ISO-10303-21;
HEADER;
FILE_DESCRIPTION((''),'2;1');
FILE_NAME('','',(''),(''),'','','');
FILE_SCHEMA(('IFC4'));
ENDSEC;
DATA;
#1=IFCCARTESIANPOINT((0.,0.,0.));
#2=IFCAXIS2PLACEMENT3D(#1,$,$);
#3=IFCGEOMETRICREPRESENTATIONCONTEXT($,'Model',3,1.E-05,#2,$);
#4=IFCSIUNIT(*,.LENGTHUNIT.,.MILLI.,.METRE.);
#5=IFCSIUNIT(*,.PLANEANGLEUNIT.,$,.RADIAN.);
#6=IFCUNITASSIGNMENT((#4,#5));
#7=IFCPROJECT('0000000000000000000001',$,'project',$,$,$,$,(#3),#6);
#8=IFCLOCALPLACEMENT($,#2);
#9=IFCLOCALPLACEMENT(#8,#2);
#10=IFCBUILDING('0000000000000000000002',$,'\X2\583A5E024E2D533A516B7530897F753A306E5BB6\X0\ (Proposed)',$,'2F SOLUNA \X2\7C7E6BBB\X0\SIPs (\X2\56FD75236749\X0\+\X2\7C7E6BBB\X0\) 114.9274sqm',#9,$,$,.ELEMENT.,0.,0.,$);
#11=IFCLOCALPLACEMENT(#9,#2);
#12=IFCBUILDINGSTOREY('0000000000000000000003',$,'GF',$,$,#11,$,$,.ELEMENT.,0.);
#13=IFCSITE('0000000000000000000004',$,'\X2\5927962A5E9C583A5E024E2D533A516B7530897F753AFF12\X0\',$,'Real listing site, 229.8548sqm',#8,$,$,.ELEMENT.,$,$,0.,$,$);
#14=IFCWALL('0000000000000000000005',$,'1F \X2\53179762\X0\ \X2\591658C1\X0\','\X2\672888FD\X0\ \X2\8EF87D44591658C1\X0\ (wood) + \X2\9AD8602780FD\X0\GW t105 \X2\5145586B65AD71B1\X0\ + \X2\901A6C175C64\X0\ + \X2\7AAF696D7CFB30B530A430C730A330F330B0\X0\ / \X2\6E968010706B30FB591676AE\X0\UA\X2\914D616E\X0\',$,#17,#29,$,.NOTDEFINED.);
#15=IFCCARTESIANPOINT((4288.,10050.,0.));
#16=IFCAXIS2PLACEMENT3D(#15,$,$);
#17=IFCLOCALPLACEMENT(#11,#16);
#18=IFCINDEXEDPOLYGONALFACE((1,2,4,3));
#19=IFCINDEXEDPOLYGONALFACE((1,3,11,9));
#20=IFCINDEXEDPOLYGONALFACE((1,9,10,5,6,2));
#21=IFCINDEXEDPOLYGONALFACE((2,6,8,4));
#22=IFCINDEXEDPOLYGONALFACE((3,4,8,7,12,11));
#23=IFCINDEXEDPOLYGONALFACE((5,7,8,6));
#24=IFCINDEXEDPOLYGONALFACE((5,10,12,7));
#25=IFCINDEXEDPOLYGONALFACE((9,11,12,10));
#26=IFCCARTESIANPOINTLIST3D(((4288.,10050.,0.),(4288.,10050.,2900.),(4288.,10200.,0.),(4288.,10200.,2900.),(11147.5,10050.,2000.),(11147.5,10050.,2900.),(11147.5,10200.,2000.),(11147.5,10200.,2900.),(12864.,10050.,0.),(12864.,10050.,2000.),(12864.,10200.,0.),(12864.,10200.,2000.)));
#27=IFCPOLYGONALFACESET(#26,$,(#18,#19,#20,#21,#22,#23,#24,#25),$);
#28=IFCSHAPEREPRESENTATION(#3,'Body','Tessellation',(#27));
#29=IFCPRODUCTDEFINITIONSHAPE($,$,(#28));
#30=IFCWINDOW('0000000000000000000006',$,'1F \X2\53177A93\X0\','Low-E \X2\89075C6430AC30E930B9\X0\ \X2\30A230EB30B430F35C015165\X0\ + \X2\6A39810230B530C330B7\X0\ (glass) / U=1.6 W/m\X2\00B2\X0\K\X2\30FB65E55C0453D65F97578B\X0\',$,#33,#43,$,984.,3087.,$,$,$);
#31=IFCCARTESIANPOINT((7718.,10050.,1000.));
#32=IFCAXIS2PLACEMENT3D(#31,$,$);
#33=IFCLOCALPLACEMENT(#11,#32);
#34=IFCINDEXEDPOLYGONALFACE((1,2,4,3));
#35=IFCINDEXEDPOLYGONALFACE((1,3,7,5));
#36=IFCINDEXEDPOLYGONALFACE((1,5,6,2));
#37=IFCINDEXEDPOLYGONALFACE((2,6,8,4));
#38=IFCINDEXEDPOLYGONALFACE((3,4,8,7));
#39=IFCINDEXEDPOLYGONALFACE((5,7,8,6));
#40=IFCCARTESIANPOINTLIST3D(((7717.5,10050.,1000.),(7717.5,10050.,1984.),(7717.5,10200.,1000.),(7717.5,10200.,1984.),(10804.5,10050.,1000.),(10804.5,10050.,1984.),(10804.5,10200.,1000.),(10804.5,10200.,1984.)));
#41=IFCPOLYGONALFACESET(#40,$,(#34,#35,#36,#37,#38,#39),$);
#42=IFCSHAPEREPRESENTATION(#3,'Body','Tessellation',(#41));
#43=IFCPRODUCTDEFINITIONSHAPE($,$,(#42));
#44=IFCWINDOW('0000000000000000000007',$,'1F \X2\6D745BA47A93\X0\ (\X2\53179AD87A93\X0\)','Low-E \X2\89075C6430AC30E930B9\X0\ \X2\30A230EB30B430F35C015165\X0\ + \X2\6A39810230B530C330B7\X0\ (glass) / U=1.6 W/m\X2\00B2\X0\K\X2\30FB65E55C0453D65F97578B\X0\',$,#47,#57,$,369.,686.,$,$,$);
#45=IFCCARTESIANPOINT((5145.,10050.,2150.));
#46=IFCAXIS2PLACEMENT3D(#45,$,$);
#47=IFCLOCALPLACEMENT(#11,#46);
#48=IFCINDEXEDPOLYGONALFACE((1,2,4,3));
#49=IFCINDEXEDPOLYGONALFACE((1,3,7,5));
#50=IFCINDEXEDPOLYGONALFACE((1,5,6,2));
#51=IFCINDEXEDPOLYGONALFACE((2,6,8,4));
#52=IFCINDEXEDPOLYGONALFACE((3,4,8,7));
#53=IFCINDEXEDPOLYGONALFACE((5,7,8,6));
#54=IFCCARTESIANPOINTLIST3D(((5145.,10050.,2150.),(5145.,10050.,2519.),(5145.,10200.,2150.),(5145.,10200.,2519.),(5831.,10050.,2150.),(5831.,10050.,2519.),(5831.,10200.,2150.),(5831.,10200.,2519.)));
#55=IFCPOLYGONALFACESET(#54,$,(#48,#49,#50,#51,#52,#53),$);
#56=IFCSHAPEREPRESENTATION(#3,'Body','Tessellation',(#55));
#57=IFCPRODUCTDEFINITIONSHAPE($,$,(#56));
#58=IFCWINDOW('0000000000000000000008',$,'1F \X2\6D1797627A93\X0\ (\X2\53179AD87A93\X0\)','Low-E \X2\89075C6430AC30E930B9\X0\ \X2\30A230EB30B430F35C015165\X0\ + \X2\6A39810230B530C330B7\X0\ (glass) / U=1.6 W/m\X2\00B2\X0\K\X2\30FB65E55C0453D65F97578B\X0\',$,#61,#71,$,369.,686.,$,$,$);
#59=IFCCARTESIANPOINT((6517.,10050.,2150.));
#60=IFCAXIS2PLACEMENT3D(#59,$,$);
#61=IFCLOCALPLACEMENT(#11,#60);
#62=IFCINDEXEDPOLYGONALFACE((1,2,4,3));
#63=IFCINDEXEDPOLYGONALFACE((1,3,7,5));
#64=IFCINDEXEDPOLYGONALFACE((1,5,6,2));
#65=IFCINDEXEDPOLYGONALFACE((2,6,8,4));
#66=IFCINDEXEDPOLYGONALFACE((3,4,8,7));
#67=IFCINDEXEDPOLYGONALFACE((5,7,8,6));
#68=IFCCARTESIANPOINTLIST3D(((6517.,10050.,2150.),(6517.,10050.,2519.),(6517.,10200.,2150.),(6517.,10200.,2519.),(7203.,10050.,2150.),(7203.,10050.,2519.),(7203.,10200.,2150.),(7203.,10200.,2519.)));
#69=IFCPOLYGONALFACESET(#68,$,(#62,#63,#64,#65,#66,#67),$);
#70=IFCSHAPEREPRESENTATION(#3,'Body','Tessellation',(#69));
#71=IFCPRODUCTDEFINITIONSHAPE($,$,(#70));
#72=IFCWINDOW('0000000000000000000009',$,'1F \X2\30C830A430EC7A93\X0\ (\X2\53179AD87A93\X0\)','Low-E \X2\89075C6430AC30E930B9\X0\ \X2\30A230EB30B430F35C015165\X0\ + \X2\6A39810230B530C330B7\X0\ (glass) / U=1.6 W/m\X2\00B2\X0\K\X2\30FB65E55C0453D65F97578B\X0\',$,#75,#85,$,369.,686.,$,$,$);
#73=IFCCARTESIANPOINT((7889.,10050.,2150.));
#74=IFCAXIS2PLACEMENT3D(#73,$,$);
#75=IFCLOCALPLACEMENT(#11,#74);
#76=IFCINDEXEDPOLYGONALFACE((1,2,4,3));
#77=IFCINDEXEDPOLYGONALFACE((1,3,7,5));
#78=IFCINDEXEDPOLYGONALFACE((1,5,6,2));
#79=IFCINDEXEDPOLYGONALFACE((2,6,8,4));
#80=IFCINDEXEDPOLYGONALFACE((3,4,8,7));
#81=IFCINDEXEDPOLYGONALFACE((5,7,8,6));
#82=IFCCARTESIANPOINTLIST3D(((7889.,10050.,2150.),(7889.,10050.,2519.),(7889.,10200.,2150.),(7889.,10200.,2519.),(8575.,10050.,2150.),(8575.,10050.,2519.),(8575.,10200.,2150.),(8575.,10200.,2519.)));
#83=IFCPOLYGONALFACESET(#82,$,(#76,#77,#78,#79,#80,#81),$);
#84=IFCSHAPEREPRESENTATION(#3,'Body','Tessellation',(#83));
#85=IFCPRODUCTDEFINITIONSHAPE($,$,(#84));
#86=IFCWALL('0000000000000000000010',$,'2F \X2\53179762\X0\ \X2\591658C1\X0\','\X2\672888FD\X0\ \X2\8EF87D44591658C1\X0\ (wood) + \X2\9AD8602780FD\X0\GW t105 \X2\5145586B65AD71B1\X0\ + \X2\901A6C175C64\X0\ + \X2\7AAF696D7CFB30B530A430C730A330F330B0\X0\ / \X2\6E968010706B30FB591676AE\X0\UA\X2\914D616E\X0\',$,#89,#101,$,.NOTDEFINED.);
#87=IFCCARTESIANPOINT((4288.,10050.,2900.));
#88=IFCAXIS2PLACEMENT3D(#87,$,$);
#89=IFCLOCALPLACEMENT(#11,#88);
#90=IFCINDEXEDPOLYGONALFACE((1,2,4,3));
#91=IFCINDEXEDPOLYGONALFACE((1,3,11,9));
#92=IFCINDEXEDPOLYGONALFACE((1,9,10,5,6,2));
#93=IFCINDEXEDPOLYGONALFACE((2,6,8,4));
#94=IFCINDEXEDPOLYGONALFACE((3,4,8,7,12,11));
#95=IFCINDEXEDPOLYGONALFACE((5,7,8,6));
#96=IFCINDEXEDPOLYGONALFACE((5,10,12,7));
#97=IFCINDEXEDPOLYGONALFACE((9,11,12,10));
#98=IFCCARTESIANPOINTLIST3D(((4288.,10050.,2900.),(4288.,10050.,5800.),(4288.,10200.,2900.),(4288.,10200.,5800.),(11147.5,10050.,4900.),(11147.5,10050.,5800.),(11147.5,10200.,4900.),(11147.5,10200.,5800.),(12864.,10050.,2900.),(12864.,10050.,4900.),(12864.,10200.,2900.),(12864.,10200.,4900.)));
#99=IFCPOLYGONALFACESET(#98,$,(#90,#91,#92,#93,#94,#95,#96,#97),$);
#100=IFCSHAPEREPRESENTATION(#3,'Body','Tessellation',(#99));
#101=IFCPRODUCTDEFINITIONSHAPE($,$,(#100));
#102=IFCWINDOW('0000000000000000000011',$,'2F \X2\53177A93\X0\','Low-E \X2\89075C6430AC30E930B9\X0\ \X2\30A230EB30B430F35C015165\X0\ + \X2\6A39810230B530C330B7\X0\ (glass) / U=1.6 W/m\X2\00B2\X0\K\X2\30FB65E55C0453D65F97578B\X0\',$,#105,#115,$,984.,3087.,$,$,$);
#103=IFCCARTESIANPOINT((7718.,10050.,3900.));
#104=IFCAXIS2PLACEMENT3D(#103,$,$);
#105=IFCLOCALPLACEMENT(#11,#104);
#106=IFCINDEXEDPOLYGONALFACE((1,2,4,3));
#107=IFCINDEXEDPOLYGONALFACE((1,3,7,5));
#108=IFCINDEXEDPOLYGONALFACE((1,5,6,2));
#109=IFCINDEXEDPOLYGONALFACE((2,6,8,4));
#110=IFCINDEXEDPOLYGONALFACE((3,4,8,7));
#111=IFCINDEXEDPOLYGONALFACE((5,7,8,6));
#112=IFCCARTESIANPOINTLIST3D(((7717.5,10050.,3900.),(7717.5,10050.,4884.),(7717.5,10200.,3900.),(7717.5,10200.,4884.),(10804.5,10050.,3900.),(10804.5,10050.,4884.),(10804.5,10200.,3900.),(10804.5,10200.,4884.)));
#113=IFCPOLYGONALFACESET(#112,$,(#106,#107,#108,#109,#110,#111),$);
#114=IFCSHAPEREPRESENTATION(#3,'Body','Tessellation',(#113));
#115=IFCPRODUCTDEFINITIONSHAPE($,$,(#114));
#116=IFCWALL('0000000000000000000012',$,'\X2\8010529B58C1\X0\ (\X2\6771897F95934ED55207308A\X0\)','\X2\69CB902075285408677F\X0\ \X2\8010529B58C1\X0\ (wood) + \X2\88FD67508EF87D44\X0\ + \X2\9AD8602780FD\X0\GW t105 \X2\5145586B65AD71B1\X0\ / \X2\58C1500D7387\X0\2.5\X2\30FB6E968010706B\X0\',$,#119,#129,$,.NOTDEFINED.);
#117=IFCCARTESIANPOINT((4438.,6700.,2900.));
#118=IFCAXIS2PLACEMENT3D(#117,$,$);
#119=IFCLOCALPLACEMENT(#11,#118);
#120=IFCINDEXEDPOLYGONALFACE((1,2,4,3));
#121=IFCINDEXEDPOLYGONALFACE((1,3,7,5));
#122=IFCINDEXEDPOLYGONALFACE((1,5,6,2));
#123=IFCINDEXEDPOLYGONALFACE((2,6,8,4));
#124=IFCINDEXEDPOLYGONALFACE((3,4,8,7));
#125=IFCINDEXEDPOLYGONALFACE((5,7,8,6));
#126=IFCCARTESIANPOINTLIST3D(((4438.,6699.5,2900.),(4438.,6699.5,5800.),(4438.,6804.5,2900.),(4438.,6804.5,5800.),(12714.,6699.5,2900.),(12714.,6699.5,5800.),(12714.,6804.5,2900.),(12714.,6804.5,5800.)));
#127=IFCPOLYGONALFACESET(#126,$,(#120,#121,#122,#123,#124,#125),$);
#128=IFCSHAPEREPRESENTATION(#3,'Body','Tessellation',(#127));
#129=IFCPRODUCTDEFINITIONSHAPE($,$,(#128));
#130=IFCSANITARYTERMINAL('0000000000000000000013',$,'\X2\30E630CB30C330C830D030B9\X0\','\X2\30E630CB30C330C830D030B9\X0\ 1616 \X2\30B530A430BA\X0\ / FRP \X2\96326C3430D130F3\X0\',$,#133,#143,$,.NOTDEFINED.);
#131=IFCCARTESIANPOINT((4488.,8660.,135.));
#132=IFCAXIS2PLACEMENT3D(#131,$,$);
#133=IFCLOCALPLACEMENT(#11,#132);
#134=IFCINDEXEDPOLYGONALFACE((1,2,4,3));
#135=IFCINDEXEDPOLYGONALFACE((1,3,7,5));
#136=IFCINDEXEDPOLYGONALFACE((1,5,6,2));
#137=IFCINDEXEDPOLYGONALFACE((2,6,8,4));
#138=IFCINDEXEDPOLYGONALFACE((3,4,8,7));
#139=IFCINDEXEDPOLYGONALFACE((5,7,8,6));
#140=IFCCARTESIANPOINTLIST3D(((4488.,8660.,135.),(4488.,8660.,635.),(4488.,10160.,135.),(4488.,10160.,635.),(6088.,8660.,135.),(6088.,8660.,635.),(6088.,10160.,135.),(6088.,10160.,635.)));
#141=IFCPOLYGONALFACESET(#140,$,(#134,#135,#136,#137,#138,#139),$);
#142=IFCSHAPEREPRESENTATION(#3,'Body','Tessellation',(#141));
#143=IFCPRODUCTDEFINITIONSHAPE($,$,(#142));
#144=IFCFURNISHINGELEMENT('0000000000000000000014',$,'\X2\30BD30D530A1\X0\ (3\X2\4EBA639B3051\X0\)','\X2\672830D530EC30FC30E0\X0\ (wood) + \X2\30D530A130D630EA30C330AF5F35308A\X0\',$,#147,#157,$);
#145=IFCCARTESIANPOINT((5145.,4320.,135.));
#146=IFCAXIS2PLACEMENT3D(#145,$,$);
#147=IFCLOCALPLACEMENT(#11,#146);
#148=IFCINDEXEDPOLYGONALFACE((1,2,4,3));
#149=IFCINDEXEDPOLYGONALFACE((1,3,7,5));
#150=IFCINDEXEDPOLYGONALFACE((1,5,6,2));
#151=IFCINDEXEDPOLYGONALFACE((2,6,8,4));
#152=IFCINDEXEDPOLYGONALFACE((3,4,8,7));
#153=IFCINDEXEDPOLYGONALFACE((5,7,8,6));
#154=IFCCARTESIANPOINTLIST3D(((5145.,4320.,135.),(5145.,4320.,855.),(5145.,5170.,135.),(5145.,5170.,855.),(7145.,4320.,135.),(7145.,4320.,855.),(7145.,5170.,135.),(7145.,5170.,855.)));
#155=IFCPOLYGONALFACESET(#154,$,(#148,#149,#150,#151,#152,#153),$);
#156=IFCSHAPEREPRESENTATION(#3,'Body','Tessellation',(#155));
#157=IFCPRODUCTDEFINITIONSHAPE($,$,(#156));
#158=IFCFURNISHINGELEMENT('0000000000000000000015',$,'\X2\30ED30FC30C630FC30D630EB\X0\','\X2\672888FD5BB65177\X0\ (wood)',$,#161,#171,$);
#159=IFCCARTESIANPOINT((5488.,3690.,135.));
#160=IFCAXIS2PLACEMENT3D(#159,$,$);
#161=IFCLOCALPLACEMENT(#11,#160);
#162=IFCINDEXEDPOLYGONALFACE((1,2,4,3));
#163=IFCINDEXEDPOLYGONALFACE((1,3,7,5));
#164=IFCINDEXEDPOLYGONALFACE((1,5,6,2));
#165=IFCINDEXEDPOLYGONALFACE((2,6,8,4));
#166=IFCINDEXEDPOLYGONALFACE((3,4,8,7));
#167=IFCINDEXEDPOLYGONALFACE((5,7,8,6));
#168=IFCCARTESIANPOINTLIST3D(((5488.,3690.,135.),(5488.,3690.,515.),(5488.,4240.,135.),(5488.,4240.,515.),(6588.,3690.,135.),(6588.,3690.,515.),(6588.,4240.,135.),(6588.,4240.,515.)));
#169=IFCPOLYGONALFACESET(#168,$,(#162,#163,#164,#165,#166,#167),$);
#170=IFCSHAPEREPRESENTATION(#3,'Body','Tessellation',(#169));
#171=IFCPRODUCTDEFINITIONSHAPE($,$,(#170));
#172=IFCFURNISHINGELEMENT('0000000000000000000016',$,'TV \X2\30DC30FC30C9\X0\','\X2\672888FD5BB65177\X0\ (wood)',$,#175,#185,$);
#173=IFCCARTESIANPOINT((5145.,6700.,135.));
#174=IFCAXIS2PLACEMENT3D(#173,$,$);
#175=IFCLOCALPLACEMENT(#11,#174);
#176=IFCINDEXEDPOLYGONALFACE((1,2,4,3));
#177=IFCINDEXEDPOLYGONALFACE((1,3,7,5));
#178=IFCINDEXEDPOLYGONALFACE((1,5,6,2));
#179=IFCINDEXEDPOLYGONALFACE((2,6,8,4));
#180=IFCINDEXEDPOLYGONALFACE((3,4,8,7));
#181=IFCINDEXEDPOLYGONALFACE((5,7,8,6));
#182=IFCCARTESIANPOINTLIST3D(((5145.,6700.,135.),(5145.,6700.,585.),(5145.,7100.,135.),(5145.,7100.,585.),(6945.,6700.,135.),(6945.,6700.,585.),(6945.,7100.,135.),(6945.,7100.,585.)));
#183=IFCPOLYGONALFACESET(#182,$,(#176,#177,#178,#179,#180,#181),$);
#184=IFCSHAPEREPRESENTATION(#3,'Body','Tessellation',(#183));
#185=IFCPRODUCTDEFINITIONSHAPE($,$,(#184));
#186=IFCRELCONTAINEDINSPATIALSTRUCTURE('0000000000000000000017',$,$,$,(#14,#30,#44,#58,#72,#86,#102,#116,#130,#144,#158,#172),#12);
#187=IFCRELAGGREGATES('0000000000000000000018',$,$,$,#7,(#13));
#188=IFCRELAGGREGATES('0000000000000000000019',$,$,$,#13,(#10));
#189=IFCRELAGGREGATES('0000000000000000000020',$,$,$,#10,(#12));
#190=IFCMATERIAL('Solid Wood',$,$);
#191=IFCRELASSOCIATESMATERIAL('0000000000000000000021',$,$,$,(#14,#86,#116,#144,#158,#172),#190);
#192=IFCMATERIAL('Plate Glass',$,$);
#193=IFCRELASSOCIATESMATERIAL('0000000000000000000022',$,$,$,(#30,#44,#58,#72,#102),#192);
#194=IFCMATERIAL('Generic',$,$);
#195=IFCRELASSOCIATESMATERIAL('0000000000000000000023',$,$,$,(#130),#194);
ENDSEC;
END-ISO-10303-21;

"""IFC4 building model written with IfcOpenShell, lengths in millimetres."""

from ifc_helpers import new_model, si_unit, frame, frame_2d, origin, place, context, project, spatial, rectangle, extrude, material, element, fill, save


model = new_model("IFC4")

# Units and contexts
model_context = context("Model", 3, precision=1e-05, world=origin())
ifc_project = project(units=[si_unit("LENGTHUNIT", "METRE", prefix="MILLI"), si_unit("PLANEANGLEUNIT", "RADIAN")], contexts=[model_context])

# Site, building, storey
site_placement = place(None, origin())
site = spatial("IfcSite", under=ifc_project, at=site_placement, Name="大阪府堺市中区八田西町２", ObjectType="Real listing site, 229.8548sqm", CompositionType="ELEMENT", RefElevation=0.0)
building_placement = place(site_placement, origin())
building = spatial("IfcBuilding", under=site, at=building_placement, Name="堺市中区八田西町の家 (Proposed)", ObjectType="2F SOLUNA 籾殻SIPs (国産杉+籾殻) 114.9274sqm", CompositionType="ELEMENT", ElevationOfRefHeight=0.0, ElevationOfTerrain=0.0)
storey_placement = place(building_placement, origin())
storey = spatial("IfcBuildingStorey", under=building, at=storey_placement, Name="GF", CompositionType="ELEMENT", Elevation=0.0)

# Wall, openings, windows
ifc_material_1 = material(Name="Solid Wood")
wall_1_placement = place(storey_placement, frame((4288.0, 10050.0, 0.0)))
wall_1 = element("IfcWall", 1, at=wall_1_placement, inside=storey, material=ifc_material_1, Name="1F 北面 外壁", Description="木製 軸組外壁 (wood) + 高性能GW t105 充填断熱 + 通気層 + 窯業系サイディング / 準耐火・外皮UA配慮", PredefinedType="NOTDEFINED", context=model_context, shape_type="SweptSolid", body=[
    extrude(rectangle(XDim=8576.0, YDim=150.0, at=frame_2d((4288.0, 75.0))), frame((4288.0, 10050.0, 0.0)), (0.0, 0.0, 1.0), 2900.0),
])
opening_1_placement = place(storey_placement, frame((7718.0, 10050.0, 1000.0)))
opening_1 = element("IfcOpeningElement", 2, at=opening_1_placement, cuts=wall_1, PredefinedType="NOTDEFINED", context=model_context, shape_type="SweptSolid", body=[
    extrude(rectangle(XDim=3087.0, YDim=150.0, at=frame_2d((1543.0, 75.0))), frame((7718.0, 10050.0, 1000.0)), (0.0, 0.0, 1.0), 984.0),
])
opening_2_placement = place(storey_placement, frame((5145.0, 10050.0, 2150.0)))
opening_2 = element("IfcOpeningElement", 3, at=opening_2_placement, cuts=wall_1, PredefinedType="NOTDEFINED", context=model_context, shape_type="SweptSolid", body=[
    extrude(rectangle(XDim=686.0, YDim=150.0, at=frame_2d((343.0, 75.0))), frame((5145.0, 10050.0, 2150.0)), (0.0, 0.0, 1.0), 369.0),
])
opening_3_placement = place(storey_placement, frame((6517.0, 10050.0, 2150.0)))
opening_3 = element("IfcOpeningElement", 4, at=opening_3_placement, cuts=wall_1, PredefinedType="NOTDEFINED", context=model_context, shape_type="SweptSolid", body=[
    extrude(rectangle(XDim=686.0, YDim=150.0, at=frame_2d((343.0, 75.0))), frame((6517.0, 10050.0, 2150.0)), (0.0, 0.0, 1.0), 369.0),
])
opening_4_placement = place(storey_placement, frame((7889.0, 10050.0, 2150.0)))
opening_4 = element("IfcOpeningElement", 5, at=opening_4_placement, cuts=wall_1, PredefinedType="NOTDEFINED", context=model_context, shape_type="SweptSolid", body=[
    extrude(rectangle(XDim=686.0, YDim=150.0, at=frame_2d((343.0, 75.0))), frame((7889.0, 10050.0, 2150.0)), (0.0, 0.0, 1.0), 369.0),
])
ifc_material_2 = material(Name="Plate Glass")
window_1_placement = place(storey_placement, frame((7718.0, 10050.0, 1000.0)))
window_1 = element("IfcWindow", 6, at=window_1_placement, inside=storey, material=ifc_material_2, Name="1F 北窓", Description="Low-E 複層ガラス アルゴン封入 + 樹脂サッシ (glass) / U=1.6 W/m²K・日射取得型", OverallHeight=984.0, OverallWidth=3087.0, context=model_context, shape_type="SweptSolid", body=[
    extrude(rectangle(XDim=3087.0, YDim=150.0, at=frame_2d((1543.0, 75.0))), frame((7718.0, 10050.0, 1000.0)), (0.0, 0.0, 1.0), 984.0),
])
fill(opening_1, window_1)
window_2_placement = place(storey_placement, frame((5145.0, 10050.0, 2150.0)))
window_2 = element("IfcWindow", 7, at=window_2_placement, inside=storey, material=ifc_material_2, Name="1F 浴室窓 (北高窓)", Description="Low-E 複層ガラス アルゴン封入 + 樹脂サッシ (glass) / U=1.6 W/m²K・日射取得型", OverallHeight=369.0, OverallWidth=686.0, context=model_context, shape_type="SweptSolid", body=[
    extrude(rectangle(XDim=686.0, YDim=150.0, at=frame_2d((343.0, 75.0))), frame((5145.0, 10050.0, 2150.0)), (0.0, 0.0, 1.0), 369.0),
])
fill(opening_2, window_2)
window_3_placement = place(storey_placement, frame((6517.0, 10050.0, 2150.0)))
window_3 = element("IfcWindow", 8, at=window_3_placement, inside=storey, material=ifc_material_2, Name="1F 洗面窓 (北高窓)", Description="Low-E 複層ガラス アルゴン封入 + 樹脂サッシ (glass) / U=1.6 W/m²K・日射取得型", OverallHeight=369.0, OverallWidth=686.0, context=model_context, shape_type="SweptSolid", body=[
    extrude(rectangle(XDim=686.0, YDim=150.0, at=frame_2d((343.0, 75.0))), frame((6517.0, 10050.0, 2150.0)), (0.0, 0.0, 1.0), 369.0),
])
fill(opening_3, window_3)
window_4_placement = place(storey_placement, frame((7889.0, 10050.0, 2150.0)))
window_4 = element("IfcWindow", 9, at=window_4_placement, inside=storey, material=ifc_material_2, Name="1F トイレ窓 (北高窓)", Description="Low-E 複層ガラス アルゴン封入 + 樹脂サッシ (glass) / U=1.6 W/m²K・日射取得型", OverallHeight=369.0, OverallWidth=686.0, context=model_context, shape_type="SweptSolid", body=[
    extrude(rectangle(XDim=686.0, YDim=150.0, at=frame_2d((343.0, 75.0))), frame((7889.0, 10050.0, 2150.0)), (0.0, 0.0, 1.0), 369.0),
])
fill(opening_4, window_4)

# Wall, opening, window
wall_2_placement = place(storey_placement, frame((4288.0, 10050.0, 2900.0)))
wall_2 = element("IfcWall", 10, at=wall_2_placement, inside=storey, material=ifc_material_1, Name="2F 北面 外壁", Description="木製 軸組外壁 (wood) + 高性能GW t105 充填断熱 + 通気層 + 窯業系サイディング / 準耐火・外皮UA配慮", PredefinedType="NOTDEFINED", context=model_context, shape_type="SweptSolid", body=[
    extrude(rectangle(XDim=8576.0, YDim=150.0, at=frame_2d((4288.0, 75.0))), frame((4288.0, 10050.0, 2900.0)), (0.0, 0.0, 1.0), 2900.0),
])
opening_5_placement = place(storey_placement, frame((7718.0, 10050.0, 3900.0)))
opening_5 = element("IfcOpeningElement", 11, at=opening_5_placement, cuts=wall_2, PredefinedType="NOTDEFINED", context=model_context, shape_type="SweptSolid", body=[
    extrude(rectangle(XDim=3087.0, YDim=150.0, at=frame_2d((1543.0, 75.0))), frame((7718.0, 10050.0, 3900.0)), (0.0, 0.0, 1.0), 984.0),
])
window_5_placement = place(storey_placement, frame((7718.0, 10050.0, 3900.0)))
window_5 = element("IfcWindow", 12, at=window_5_placement, inside=storey, material=ifc_material_2, Name="2F 北窓", Description="Low-E 複層ガラス アルゴン封入 + 樹脂サッシ (glass) / U=1.6 W/m²K・日射取得型", OverallHeight=984.0, OverallWidth=3087.0, context=model_context, shape_type="SweptSolid", body=[
    extrude(rectangle(XDim=3087.0, YDim=150.0, at=frame_2d((1543.0, 75.0))), frame((7718.0, 10050.0, 3900.0)), (0.0, 0.0, 1.0), 984.0),
])
fill(opening_5, window_5)

# Wall
wall_3_placement = place(storey_placement, frame((4438.0, 6700.0, 2900.0)))
element("IfcWall", 13, at=wall_3_placement, inside=storey, material=ifc_material_1, Name="耐力壁 (東西間仕切り)", Description="構造用合板 耐力壁 (wood) + 製材軸組 + 高性能GW t105 充填断熱 / 壁倍率2.5・準耐火", PredefinedType="NOTDEFINED", context=model_context, shape_type="SweptSolid", body=[
    extrude(rectangle(XDim=8276.0, YDim=105.0, at=frame_2d((4138.0, 52.0))), frame((4438.0, 6700.0, 2900.0)), (0.0, 0.0, 1.0), 2900.0),
])

# Sanitary terminal
ifc_material_3 = material(Name="Generic")
sanitary_terminal_placement = place(storey_placement, frame((4488.0, 8660.0, 135.0)))
element("IfcSanitaryTerminal", 14, at=sanitary_terminal_placement, inside=storey, material=ifc_material_3, Name="ユニットバス", Description="ユニットバス 1616 サイズ / FRP 防水パン", PredefinedType="NOTDEFINED", context=model_context, shape_type="SweptSolid", body=[
    extrude(rectangle(XDim=1600.0, YDim=1500.0, at=frame_2d((800.0, 750.0))), frame((4488.0, 8660.0, 135.0)), (0.0, 0.0, 1.0), 500.0),
])

# Furnishing elements
furnishing_1_placement = place(storey_placement, frame((5145.0, 4320.0, 135.0)))
element("IfcFurnishingElement", 15, at=furnishing_1_placement, inside=storey, material=ifc_material_1, Name="ソファ (3人掛け)", Description="木フレーム (wood) + ファブリック張り", context=model_context, shape_type="SweptSolid", body=[
    extrude(rectangle(XDim=2000.0, YDim=850.0, at=frame_2d((1000.0, 425.0))), frame((5145.0, 4320.0, 135.0)), (0.0, 0.0, 1.0), 720.0),
])
furnishing_2_placement = place(storey_placement, frame((5488.0, 3690.0, 135.0)))
element("IfcFurnishingElement", 16, at=furnishing_2_placement, inside=storey, material=ifc_material_1, Name="ローテーブル", Description="木製家具 (wood)", context=model_context, shape_type="SweptSolid", body=[
    extrude(rectangle(XDim=1100.0, YDim=550.0, at=frame_2d((550.0, 275.0))), frame((5488.0, 3690.0, 135.0)), (0.0, 0.0, 1.0), 380.0),
])
furnishing_3_placement = place(storey_placement, frame((5145.0, 6700.0, 135.0)))
element("IfcFurnishingElement", 17, at=furnishing_3_placement, inside=storey, material=ifc_material_1, Name="TV ボード", Description="木製家具 (wood)", context=model_context, shape_type="SweptSolid", body=[
    extrude(rectangle(XDim=1800.0, YDim=400.0, at=frame_2d((900.0, 200.0))), frame((5145.0, 6700.0, 135.0)), (0.0, 0.0, 1.0), 450.0),
])

save(model, "model.ifc")
